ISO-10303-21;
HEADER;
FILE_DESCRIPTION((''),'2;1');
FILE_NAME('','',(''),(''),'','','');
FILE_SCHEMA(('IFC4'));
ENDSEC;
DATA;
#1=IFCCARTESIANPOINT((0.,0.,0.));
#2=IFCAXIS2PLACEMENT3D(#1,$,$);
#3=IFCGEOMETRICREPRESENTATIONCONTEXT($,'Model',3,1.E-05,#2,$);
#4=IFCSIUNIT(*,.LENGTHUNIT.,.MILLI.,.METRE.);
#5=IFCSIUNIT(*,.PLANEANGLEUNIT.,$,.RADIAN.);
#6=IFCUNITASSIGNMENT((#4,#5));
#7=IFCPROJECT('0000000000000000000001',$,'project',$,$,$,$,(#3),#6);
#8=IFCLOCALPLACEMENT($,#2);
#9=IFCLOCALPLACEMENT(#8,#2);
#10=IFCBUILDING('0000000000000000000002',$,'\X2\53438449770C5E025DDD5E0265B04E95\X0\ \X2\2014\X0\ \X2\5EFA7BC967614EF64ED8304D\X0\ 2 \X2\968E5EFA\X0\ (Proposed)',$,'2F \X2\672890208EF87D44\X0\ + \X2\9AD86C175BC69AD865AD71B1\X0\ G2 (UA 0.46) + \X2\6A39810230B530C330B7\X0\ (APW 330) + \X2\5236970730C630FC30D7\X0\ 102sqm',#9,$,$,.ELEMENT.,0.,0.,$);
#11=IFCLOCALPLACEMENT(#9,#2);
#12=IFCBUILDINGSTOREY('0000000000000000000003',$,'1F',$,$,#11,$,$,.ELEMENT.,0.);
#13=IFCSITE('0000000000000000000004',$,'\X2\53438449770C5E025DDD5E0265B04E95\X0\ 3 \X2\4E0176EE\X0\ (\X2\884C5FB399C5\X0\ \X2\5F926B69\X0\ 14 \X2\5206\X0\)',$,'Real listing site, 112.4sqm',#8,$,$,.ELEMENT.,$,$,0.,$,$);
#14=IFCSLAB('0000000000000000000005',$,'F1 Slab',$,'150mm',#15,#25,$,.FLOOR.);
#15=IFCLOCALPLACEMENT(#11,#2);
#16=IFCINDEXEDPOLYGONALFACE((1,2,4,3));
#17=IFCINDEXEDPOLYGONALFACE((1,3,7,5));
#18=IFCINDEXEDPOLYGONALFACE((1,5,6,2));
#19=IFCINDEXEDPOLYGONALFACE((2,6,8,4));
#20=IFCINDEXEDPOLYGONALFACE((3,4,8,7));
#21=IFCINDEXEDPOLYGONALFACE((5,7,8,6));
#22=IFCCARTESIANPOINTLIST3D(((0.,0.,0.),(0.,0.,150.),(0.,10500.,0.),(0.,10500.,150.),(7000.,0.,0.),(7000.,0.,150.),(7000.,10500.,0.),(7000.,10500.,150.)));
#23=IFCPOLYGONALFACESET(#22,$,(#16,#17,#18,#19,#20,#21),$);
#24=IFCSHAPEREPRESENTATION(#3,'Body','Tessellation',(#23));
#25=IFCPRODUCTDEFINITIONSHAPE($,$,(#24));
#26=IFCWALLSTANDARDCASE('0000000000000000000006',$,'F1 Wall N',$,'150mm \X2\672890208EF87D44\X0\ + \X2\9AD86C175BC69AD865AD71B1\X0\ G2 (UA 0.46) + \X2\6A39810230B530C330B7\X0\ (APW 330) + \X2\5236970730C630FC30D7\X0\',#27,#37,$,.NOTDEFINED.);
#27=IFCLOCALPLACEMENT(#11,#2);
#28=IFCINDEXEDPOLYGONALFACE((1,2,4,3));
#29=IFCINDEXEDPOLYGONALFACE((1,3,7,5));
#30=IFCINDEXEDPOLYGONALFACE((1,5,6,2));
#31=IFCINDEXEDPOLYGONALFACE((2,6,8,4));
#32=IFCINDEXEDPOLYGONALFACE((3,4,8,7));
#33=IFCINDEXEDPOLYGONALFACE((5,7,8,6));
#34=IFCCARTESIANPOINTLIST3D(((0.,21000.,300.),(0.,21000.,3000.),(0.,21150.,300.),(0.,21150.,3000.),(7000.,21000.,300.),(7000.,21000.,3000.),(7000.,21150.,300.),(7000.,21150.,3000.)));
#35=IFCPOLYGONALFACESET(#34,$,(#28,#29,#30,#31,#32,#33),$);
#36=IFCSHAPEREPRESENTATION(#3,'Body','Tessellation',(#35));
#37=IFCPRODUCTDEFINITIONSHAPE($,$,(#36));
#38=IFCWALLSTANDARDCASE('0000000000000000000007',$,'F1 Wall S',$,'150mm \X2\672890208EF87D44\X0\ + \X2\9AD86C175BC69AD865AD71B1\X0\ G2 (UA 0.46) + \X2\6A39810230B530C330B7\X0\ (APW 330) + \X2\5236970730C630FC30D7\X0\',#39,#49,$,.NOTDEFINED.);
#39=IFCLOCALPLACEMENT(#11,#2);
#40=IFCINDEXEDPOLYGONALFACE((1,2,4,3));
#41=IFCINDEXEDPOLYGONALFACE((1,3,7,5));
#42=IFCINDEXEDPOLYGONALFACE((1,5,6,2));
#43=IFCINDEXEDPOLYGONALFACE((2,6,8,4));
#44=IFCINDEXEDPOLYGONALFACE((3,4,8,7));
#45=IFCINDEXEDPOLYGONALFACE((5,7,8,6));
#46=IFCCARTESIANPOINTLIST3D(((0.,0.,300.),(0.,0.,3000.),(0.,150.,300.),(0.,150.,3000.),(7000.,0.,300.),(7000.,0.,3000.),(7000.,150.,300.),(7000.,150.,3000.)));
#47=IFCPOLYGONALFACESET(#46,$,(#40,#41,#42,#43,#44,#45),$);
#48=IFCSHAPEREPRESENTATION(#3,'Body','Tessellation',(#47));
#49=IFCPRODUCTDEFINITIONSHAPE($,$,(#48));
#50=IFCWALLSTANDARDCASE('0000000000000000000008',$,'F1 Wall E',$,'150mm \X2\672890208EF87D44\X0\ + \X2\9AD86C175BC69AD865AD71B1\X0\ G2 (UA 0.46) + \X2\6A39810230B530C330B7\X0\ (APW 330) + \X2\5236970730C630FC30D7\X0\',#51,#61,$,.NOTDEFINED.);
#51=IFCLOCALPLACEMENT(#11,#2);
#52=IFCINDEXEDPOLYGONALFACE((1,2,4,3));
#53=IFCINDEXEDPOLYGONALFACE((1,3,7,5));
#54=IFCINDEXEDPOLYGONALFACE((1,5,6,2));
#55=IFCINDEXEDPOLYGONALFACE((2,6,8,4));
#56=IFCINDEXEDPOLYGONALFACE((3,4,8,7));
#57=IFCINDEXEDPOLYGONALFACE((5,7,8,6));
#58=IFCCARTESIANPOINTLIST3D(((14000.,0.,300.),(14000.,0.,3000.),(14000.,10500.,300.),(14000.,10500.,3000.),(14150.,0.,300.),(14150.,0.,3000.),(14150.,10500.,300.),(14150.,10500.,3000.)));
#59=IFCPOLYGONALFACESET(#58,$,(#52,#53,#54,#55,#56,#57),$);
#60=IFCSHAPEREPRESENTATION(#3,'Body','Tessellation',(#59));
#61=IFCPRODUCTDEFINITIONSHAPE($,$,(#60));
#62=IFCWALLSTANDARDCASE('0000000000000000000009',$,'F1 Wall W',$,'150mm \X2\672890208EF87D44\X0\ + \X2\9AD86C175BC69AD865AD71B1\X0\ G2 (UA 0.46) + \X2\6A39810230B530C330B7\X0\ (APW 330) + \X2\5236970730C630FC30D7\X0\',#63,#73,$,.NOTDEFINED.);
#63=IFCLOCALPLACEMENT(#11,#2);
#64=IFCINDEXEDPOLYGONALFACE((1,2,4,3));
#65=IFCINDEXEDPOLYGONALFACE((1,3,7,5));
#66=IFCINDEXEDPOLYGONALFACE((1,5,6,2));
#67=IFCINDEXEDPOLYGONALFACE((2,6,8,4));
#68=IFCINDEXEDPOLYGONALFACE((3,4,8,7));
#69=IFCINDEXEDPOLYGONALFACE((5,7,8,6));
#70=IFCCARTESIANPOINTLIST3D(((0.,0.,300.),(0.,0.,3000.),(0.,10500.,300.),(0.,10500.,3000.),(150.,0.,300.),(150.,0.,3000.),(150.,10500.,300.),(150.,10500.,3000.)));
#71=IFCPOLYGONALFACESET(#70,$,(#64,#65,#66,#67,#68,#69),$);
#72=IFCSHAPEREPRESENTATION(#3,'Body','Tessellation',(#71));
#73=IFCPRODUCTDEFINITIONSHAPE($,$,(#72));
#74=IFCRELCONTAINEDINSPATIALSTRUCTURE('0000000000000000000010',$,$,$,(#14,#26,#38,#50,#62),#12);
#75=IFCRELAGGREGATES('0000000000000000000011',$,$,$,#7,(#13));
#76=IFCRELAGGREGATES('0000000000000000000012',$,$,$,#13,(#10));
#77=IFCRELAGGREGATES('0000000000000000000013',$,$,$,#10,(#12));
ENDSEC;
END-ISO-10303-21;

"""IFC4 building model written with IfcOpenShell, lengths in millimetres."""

from ifc_helpers import new_model, si_unit, frame, frame_2d, origin, place, context, project, spatial, rectangle, extrude, element, save


model = new_model("IFC4")

# Units and contexts
model_context = context("Model", 3, precision=1e-05, world=origin())
ifc_project = project(units=[si_unit("LENGTHUNIT", "METRE", prefix="MILLI"), si_unit("PLANEANGLEUNIT", "RADIAN")], contexts=[model_context])

# Site, building, storey
site_placement = place(None, origin())
site = spatial("IfcSite", under=ifc_project, at=site_placement, Name="千葉県市川市新井 3 丁目 (行徳駅 徒歩 14 分)", ObjectType="Real listing site, 112.4sqm", CompositionType="ELEMENT", RefElevation=0.0)
building_placement = place(site_placement, origin())
building = spatial("IfcBuilding", under=site, at=building_placement, Name="千葉県市川市新井 — 建築条件付き 2 階建 (Proposed)", ObjectType="2F 木造軸組 + 高気密高断熱 G2 (UA 0.46) + 樹脂サッシ (APW 330) + 制震テープ 102sqm", CompositionType="ELEMENT", ElevationOfRefHeight=0.0, ElevationOfTerrain=0.0)
storey_placement = place(building_placement, origin())
storey = spatial("IfcBuildingStorey", under=building, at=storey_placement, Name="1F", CompositionType="ELEMENT", Elevation=0.0)

# Slab
slab_placement = place(storey_placement, origin())
element("IfcSlab", 1, at=slab_placement, inside=storey, Name="F1 Slab", ObjectType="150mm", PredefinedType="FLOOR", context=model_context, shape_type="SweptSolid", body=[
    extrude(rectangle(XDim=7000.0, YDim=10500.0, at=frame_2d((3500.0, 5250.0))), origin(), (0.0, 0.0, 1.0), 150.0),
])

# Walls
wall_1_placement = place(storey_placement, frame((0.0, 10500.0, 150.0)))
element("IfcWallStandardCase", 2, at=wall_1_placement, inside=storey, Name="F1 Wall N", ObjectType="150mm 木造軸組 + 高気密高断熱 G2 (UA 0.46) + 樹脂サッシ (APW 330) + 制震テープ", PredefinedType="NOTDEFINED", context=model_context, shape_type="SweptSolid", body=[
    extrude(rectangle(XDim=7000.0, YDim=150.0, at=frame_2d((3500.0, 75.0))), frame((0.0, 10500.0, 150.0)), (0.0, 0.0, 1.0), 2700.0),
])
wall_2_placement = place(storey_placement, frame((0.0, 0.0, 150.0)))
element("IfcWallStandardCase", 3, at=wall_2_placement, inside=storey, Name="F1 Wall S", ObjectType="150mm 木造軸組 + 高気密高断熱 G2 (UA 0.46) + 樹脂サッシ (APW 330) + 制震テープ", PredefinedType="NOTDEFINED", context=model_context, shape_type="SweptSolid", body=[
    extrude(rectangle(XDim=7000.0, YDim=150.0, at=frame_2d((3500.0, 75.0))), frame((0.0, 0.0, 150.0)), (0.0, 0.0, 1.0), 2700.0),
])
wall_3_placement = place(storey_placement, frame((7000.0, 0.0, 150.0)))
element("IfcWallStandardCase", 4, at=wall_3_placement, inside=storey, Name="F1 Wall E", ObjectType="150mm 木造軸組 + 高気密高断熱 G2 (UA 0.46) + 樹脂サッシ (APW 330) + 制震テープ", PredefinedType="NOTDEFINED", context=model_context, shape_type="SweptSolid", body=[
    extrude(rectangle(XDim=150.0, YDim=10500.0, at=frame_2d((75.0, 5250.0))), frame((7000.0, 0.0, 150.0)), (0.0, 0.0, 1.0), 2700.0),
])
wall_4_placement = place(storey_placement, frame((0.0, 0.0, 150.0)))
element("IfcWallStandardCase", 5, at=wall_4_placement, inside=storey, Name="F1 Wall W", ObjectType="150mm 木造軸組 + 高気密高断熱 G2 (UA 0.46) + 樹脂サッシ (APW 330) + 制震テープ", PredefinedType="NOTDEFINED", context=model_context, shape_type="SweptSolid", body=[
    extrude(rectangle(XDim=150.0, YDim=10500.0, at=frame_2d((75.0, 5250.0))), frame((0.0, 0.0, 150.0)), (0.0, 0.0, 1.0), 2700.0),
])

save(model, "model.ifc")
